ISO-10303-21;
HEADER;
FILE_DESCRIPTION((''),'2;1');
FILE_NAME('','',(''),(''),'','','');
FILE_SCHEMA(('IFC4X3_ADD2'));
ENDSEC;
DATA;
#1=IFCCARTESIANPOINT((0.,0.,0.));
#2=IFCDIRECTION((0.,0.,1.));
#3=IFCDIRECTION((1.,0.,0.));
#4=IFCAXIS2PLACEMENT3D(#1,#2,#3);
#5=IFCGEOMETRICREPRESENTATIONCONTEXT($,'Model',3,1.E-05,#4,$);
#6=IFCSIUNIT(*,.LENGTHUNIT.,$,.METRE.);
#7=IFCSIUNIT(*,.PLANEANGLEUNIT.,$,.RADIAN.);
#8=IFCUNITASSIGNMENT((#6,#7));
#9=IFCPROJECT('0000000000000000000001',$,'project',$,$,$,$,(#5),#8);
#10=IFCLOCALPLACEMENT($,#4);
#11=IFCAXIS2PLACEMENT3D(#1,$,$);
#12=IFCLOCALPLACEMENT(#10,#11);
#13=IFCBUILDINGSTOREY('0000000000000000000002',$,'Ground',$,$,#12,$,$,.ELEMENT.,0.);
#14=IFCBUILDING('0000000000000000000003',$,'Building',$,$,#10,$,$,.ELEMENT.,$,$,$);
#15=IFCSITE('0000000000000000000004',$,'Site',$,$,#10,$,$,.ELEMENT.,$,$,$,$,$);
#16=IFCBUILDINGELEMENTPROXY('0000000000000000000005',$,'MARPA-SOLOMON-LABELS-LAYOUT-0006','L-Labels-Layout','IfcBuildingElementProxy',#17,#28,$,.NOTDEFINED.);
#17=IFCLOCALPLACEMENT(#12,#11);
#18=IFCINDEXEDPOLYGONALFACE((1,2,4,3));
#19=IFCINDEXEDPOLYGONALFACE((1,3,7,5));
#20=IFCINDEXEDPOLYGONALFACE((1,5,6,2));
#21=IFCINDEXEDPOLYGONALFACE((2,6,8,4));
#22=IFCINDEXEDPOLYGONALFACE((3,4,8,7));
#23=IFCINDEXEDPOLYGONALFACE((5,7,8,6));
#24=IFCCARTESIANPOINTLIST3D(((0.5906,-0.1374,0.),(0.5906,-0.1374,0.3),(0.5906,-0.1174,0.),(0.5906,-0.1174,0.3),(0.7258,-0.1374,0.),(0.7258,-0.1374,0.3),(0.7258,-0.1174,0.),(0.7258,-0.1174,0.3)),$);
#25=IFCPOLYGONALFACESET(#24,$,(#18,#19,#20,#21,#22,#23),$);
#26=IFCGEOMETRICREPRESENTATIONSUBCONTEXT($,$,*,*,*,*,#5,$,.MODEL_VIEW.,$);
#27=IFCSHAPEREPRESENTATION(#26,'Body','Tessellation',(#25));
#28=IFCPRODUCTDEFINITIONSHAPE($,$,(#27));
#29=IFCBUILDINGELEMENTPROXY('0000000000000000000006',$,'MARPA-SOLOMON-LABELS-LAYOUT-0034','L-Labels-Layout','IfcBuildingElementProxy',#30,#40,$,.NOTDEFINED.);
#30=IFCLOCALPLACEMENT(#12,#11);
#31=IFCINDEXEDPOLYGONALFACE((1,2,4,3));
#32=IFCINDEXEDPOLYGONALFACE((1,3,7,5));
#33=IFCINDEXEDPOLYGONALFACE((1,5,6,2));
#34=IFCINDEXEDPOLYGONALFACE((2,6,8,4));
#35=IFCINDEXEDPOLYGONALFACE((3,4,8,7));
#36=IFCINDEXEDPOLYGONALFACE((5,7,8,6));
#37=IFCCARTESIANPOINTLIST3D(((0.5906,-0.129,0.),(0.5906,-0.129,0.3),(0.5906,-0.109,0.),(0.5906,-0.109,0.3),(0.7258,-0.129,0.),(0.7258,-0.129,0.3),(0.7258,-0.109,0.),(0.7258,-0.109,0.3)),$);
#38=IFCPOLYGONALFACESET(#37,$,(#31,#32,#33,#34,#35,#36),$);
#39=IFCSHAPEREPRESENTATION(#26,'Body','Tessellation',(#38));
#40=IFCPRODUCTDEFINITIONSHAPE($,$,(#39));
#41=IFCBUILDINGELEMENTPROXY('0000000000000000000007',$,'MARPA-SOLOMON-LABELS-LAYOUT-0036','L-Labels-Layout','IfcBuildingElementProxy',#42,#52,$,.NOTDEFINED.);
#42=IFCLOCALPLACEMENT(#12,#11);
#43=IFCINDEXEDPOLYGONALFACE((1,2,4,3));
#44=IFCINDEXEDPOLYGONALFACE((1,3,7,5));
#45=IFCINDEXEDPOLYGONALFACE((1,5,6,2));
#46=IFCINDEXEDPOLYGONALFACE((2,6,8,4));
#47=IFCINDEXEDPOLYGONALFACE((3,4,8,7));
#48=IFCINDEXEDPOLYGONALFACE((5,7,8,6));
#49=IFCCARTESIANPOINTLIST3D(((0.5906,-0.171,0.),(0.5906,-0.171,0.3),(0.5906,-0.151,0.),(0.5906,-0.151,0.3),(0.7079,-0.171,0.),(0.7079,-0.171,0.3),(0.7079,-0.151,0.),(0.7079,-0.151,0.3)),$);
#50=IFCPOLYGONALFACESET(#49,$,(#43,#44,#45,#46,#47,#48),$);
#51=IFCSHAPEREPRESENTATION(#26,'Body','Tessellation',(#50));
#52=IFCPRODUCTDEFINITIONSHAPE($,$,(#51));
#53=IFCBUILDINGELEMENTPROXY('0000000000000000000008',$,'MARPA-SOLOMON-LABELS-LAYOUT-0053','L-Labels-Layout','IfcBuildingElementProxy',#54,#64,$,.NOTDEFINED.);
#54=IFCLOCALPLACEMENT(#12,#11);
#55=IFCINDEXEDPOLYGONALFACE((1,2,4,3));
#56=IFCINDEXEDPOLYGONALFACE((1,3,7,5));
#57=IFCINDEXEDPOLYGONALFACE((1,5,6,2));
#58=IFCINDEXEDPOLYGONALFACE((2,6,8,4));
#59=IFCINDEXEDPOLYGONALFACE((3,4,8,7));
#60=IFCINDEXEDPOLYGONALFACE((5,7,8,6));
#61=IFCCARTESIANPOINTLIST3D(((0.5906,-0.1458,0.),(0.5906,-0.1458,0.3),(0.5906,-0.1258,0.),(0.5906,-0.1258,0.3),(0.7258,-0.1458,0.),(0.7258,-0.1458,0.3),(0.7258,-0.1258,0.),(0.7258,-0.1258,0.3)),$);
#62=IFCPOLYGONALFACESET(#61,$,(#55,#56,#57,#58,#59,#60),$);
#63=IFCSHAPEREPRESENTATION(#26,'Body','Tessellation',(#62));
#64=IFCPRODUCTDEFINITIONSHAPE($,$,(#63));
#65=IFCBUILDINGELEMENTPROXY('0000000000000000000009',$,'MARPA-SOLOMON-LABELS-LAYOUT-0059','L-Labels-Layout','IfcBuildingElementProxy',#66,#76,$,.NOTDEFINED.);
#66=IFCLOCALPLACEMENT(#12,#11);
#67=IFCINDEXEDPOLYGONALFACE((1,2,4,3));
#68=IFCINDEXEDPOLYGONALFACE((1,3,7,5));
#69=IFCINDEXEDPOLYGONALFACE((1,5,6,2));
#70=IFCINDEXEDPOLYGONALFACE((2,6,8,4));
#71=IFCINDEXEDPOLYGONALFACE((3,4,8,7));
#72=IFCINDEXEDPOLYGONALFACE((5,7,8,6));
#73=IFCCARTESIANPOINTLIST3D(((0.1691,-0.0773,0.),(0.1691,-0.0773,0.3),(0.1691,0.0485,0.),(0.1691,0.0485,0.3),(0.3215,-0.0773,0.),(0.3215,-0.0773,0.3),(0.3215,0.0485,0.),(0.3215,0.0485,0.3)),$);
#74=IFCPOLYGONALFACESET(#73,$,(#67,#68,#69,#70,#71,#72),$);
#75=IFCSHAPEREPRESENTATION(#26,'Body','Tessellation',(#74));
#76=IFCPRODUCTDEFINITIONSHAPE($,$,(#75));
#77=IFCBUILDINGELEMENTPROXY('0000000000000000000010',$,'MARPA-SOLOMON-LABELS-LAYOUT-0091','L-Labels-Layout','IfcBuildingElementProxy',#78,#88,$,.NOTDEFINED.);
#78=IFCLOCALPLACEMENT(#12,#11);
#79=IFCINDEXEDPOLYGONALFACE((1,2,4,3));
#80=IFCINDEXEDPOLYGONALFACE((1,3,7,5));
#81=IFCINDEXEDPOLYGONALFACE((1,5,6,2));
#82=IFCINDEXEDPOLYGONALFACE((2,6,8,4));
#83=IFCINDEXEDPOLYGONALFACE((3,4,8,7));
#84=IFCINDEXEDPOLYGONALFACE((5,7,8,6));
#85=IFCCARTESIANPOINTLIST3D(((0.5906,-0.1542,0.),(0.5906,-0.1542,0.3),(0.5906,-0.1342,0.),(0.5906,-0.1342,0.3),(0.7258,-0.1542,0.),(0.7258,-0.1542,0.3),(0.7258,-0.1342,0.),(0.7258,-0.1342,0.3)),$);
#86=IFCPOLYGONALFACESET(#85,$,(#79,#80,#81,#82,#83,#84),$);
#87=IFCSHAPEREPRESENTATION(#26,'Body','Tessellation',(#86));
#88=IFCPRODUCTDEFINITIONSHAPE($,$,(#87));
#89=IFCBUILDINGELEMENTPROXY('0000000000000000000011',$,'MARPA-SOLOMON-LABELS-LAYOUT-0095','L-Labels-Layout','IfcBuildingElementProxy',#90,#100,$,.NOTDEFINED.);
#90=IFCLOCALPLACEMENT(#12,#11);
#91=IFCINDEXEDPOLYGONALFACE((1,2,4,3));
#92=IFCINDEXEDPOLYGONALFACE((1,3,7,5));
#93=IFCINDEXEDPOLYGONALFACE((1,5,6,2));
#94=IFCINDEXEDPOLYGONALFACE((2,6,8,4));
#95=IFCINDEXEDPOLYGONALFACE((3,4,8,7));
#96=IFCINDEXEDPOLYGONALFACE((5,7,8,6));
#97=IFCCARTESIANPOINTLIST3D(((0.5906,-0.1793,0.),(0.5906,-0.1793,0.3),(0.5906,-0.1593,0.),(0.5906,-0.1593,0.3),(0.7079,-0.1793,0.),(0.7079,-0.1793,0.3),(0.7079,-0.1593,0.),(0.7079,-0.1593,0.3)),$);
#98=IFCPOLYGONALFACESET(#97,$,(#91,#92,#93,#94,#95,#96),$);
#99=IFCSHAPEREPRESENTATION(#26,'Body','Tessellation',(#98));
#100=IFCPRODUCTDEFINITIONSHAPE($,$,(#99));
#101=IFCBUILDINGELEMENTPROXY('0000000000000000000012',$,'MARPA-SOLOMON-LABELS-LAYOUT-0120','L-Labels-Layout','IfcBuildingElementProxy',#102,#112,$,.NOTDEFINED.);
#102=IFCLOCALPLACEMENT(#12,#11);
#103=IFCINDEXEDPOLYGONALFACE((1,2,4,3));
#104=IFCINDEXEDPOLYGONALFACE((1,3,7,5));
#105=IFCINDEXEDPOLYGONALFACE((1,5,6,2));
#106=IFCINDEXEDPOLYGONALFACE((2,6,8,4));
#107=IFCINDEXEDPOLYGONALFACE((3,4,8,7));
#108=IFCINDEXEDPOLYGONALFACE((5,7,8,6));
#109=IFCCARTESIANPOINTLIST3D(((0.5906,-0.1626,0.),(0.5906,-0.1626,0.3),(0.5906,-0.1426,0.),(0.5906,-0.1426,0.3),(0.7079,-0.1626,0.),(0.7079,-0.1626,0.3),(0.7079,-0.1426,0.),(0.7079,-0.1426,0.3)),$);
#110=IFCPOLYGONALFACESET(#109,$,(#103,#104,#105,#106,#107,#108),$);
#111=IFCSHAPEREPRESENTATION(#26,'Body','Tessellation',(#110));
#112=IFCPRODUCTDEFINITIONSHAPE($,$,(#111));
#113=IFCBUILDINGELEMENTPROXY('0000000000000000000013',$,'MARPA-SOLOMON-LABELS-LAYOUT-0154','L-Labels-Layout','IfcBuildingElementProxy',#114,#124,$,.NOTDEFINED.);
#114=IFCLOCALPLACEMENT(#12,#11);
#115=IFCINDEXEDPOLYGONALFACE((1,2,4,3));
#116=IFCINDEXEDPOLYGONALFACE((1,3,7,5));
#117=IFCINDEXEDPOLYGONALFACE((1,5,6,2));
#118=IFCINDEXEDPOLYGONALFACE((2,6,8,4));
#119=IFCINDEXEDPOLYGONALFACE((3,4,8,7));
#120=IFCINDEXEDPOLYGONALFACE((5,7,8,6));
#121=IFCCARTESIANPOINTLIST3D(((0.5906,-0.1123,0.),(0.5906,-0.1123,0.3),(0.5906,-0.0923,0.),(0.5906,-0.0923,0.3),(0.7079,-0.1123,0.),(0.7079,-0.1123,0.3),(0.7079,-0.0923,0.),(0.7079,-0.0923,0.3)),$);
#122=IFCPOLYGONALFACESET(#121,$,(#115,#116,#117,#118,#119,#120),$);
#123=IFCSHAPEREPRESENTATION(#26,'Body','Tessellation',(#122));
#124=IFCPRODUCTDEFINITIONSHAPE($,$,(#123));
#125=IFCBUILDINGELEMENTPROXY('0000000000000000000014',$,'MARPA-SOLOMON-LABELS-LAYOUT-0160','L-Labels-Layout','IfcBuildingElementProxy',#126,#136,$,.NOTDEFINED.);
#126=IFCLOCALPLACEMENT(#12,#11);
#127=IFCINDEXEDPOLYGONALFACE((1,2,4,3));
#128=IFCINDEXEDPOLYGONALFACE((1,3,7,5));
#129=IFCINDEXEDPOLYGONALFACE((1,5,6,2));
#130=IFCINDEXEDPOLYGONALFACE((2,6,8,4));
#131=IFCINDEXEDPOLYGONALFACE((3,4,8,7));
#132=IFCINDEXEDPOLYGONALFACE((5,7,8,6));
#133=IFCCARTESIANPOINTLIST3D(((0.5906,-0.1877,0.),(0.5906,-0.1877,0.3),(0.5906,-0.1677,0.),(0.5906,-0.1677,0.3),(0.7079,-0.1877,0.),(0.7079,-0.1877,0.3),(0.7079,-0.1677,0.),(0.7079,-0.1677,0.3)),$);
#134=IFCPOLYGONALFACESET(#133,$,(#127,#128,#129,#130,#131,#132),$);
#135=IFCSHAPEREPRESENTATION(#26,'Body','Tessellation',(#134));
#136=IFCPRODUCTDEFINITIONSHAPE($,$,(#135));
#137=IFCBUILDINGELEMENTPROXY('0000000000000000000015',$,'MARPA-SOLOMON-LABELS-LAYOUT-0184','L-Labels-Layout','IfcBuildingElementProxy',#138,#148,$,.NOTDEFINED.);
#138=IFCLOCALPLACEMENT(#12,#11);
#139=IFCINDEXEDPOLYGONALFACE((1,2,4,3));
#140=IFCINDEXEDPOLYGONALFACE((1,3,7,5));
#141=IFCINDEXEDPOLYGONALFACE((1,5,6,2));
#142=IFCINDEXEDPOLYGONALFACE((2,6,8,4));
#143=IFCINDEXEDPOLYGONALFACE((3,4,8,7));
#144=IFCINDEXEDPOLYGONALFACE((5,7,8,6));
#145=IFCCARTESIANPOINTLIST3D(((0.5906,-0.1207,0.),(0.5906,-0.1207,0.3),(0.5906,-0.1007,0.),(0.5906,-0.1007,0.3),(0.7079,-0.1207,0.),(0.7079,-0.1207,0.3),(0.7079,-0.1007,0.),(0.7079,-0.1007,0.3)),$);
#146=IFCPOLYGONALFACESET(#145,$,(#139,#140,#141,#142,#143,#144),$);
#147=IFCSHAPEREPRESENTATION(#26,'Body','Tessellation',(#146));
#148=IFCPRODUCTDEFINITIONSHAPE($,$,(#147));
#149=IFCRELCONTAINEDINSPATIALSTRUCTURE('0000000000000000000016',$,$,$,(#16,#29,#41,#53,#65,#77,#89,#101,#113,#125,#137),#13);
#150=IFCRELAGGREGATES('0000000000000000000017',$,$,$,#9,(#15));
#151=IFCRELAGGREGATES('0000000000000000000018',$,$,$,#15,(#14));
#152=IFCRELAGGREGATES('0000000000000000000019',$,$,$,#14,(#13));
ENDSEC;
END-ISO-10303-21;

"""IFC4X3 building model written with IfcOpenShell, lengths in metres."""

from ifc_helpers import new_model, si_unit, frame, frame_2d, origin, origin_with_axes, place, context, subcontext, project, spatial, polyline, rectangle, outline, extrude, element, save


model = new_model("IFC4X3")

# Units and contexts
model_context = context("Model", 3, precision=1e-05, world=origin_with_axes())
sub_context = subcontext(model_context, None, None, "MODEL_VIEW")
ifc_project = project(units=[si_unit("LENGTHUNIT", "METRE"), si_unit("PLANEANGLEUNIT", "RADIAN")], contexts=[model_context])

# Site, building, storey
placement = place(None, origin_with_axes())
site = spatial("IfcSite", under=ifc_project, at=placement, Name="Site", CompositionType="ELEMENT")
building = spatial("IfcBuilding", under=site, at=placement, Name="Building", CompositionType="ELEMENT")
storey_placement = place(placement, origin())
storey = spatial("IfcBuildingStorey", under=building, at=storey_placement, Name="Ground", CompositionType="ELEMENT", Elevation=0.0)

# Building element proxies
for number, where, name in (
    (1, (0.5906, -0.1374, 0.0), "MARPA-SOLOMON-LABELS-LAYOUT-0006"),
    (2, (0.5906, -0.129, 0.0), "MARPA-SOLOMON-LABELS-LAYOUT-0034"),
):
    element("IfcBuildingElementProxy", number, at=place(placement, frame(where)), inside=storey, Name=name, Description="L-Labels-Layout", ObjectType="IfcBuildingElementProxy", PredefinedType="NOTDEFINED", context=sub_context, shape_type="SweptSolid", body=[
        extrude(rectangle(XDim=0.1352, YDim=0.02, at=frame_2d((0.0676, 0.01))), origin(), (0.0, 0.0, 1.0), 0.3),
    ])
proxy_1_placement = place(placement, frame((0.5906, -0.171, 0.0)))
element("IfcBuildingElementProxy", 3, at=proxy_1_placement, inside=storey, Name="MARPA-SOLOMON-LABELS-LAYOUT-0036", Description="L-Labels-Layout", ObjectType="IfcBuildingElementProxy", PredefinedType="NOTDEFINED", context=sub_context, shape_type="SweptSolid", body=[
    extrude(rectangle(XDim=0.1174, YDim=0.02, at=frame_2d((0.0587, 0.01))), origin(), (0.0, 0.0, 1.0), 0.3),
])
for number, where, name in (
    (4, (0.5906, -0.1458, 0.0), "MARPA-SOLOMON-LABELS-LAYOUT-0053"),
):
    element("IfcBuildingElementProxy", number, at=place(placement, frame(where)), inside=storey, Name=name, Description="L-Labels-Layout", ObjectType="IfcBuildingElementProxy", PredefinedType="NOTDEFINED", context=sub_context, shape_type="SweptSolid", body=[
        extrude(rectangle(XDim=0.1352, YDim=0.02, at=frame_2d((0.0676, 0.01))), origin(), (0.0, 0.0, 1.0), 0.3),
    ])
proxy_2_placement = place(placement, frame((0.1691, -0.0773, 0.0)))
element("IfcBuildingElementProxy", 5, at=proxy_2_placement, inside=storey, Name="MARPA-SOLOMON-LABELS-LAYOUT-0059", Description="L-Labels-Layout", ObjectType="IfcBuildingElementProxy", PredefinedType="NOTDEFINED", context=sub_context, shape_type="SweptSolid", body=[
    extrude(outline(polyline([(0.0, 0.1257), (0.1524, 0.1257), (0.1524, 0.0), (0.0, 0.0), (0.0, 0.1257)])), origin(), (0.0, 0.0, 1.0), 0.3),
])
for number, where, name in (
    (6, (0.5906, -0.1542, 0.0), "MARPA-SOLOMON-LABELS-LAYOUT-0091"),
):
    element("IfcBuildingElementProxy", number, at=place(placement, frame(where)), inside=storey, Name=name, Description="L-Labels-Layout", ObjectType="IfcBuildingElementProxy", PredefinedType="NOTDEFINED", context=sub_context, shape_type="SweptSolid", body=[
        extrude(rectangle(XDim=0.1352, YDim=0.02, at=frame_2d((0.0676, 0.01))), origin(), (0.0, 0.0, 1.0), 0.3),
    ])
for number, where, name in (
    (7, (0.5906, -0.1793, 0.0), "MARPA-SOLOMON-LABELS-LAYOUT-0095"),
    (8, (0.5906, -0.1626, 0.0), "MARPA-SOLOMON-LABELS-LAYOUT-0120"),
):
    element("IfcBuildingElementProxy", number, at=place(placement, frame(where)), inside=storey, Name=name, Description="L-Labels-Layout", ObjectType="IfcBuildingElementProxy", PredefinedType="NOTDEFINED", context=sub_context, shape_type="SweptSolid", body=[
        extrude(rectangle(XDim=0.1174, YDim=0.02, at=frame_2d((0.0587, 0.01))), origin(), (0.0, 0.0, 1.0), 0.3),
    ])
for number, where, name in (
    (9, (0.5906, -0.1123, 0.0), "MARPA-SOLOMON-LABELS-LAYOUT-0154"),
    (10, (0.5906, -0.1877, 0.0), "MARPA-SOLOMON-LABELS-LAYOUT-0160"),
    (11, (0.5906, -0.1207, 0.0), "MARPA-SOLOMON-LABELS-LAYOUT-0184"),
):
    element("IfcBuildingElementProxy", number, at=place(placement, frame(where)), inside=storey, Name=name, Description="L-Labels-Layout", ObjectType="IfcBuildingElementProxy", PredefinedType="NOTDEFINED", context=sub_context, shape_type="SweptSolid", body=[
        extrude(rectangle(XDim=0.1174, YDim=0.02, at=frame_2d((0.0587, 0.01))), origin(), (0.0, 0.0, 1.0), 0.3),
    ])

save(model, "model.ifc")
